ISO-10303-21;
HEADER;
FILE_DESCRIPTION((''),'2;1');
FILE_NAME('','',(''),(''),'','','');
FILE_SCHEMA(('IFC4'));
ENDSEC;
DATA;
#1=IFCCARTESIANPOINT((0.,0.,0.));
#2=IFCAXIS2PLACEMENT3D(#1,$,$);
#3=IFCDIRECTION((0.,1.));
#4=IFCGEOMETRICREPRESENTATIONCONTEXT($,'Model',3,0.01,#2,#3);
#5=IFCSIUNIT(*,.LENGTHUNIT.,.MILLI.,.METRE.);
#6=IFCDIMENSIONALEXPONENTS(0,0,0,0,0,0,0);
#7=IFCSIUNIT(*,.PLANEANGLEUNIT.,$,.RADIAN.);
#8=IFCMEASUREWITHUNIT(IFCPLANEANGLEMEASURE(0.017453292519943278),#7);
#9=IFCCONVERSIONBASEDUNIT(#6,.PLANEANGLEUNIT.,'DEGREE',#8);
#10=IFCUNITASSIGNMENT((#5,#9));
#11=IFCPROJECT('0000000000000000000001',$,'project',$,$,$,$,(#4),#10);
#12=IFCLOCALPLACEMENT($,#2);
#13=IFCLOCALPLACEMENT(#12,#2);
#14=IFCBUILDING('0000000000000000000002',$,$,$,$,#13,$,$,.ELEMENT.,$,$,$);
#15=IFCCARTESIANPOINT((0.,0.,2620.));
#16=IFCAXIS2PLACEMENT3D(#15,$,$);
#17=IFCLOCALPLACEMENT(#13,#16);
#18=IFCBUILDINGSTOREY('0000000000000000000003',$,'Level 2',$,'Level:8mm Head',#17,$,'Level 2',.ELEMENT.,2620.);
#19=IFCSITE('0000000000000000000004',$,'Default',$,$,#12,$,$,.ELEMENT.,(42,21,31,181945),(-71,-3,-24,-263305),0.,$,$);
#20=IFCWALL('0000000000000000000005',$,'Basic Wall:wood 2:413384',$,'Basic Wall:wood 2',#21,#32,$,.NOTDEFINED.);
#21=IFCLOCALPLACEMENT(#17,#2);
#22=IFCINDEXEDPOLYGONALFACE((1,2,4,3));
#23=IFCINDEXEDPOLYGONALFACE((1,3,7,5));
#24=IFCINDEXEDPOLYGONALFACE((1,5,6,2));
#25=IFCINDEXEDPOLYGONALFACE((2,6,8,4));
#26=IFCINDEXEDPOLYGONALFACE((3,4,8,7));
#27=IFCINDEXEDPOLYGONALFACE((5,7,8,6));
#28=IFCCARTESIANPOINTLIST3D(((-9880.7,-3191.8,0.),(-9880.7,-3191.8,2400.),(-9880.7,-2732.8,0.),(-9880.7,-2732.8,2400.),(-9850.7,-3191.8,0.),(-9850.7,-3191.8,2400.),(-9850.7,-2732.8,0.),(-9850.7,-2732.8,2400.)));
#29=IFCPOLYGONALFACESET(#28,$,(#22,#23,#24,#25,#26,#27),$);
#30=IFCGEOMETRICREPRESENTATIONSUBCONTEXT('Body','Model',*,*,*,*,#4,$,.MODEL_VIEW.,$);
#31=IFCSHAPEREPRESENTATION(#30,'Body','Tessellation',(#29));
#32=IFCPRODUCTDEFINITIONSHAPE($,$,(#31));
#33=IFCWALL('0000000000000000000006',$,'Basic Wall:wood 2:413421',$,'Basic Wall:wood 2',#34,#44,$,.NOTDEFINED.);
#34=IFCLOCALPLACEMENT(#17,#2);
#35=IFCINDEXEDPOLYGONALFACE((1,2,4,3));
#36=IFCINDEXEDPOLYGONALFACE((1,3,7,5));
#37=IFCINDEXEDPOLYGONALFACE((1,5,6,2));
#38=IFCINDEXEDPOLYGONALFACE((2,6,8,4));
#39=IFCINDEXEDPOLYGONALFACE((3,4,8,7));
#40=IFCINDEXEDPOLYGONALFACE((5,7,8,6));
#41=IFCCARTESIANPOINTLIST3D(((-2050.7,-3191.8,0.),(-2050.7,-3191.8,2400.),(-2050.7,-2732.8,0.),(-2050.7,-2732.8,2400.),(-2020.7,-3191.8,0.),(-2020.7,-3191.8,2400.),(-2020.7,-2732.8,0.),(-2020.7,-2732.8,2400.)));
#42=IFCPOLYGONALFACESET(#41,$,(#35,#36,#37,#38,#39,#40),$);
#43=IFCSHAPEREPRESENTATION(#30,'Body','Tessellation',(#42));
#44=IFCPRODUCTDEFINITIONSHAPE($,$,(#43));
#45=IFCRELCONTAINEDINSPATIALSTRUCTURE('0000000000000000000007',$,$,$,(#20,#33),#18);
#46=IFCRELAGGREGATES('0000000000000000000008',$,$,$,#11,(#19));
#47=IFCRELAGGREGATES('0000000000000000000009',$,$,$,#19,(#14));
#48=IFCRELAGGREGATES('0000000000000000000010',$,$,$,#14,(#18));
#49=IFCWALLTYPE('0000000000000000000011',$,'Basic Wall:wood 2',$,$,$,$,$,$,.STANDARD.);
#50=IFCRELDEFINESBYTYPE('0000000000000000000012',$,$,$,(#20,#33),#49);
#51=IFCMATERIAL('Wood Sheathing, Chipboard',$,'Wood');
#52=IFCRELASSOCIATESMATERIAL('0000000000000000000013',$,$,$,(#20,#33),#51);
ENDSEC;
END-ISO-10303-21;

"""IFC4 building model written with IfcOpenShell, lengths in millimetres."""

from ifc_helpers import new_model, entity, si_unit, converted_unit, direction, frame, origin, place, context, subcontext, project, spatial, indexed_curve, outline, extrude, material, type_object, element, save


model = new_model("IFC4")

# Units and contexts
model_context = context("Model", 3, precision=0.01, world=origin(), true_north=direction((0.0, 1.0)))
body_context = subcontext(model_context, "Body", "Model", "MODEL_VIEW")
ifc_project = project(units=[si_unit("LENGTHUNIT", "METRE", prefix="MILLI"), converted_unit("PLANEANGLEUNIT", "DEGREE", entity("IfcPlaneAngleMeasure", 0.017453292519943278), si_unit("PLANEANGLEUNIT", "RADIAN"), dimensions=[0, 0, 0, 0, 0, 0, 0])], contexts=[model_context])

# Site, building, storey
site_placement = place(None, origin())
site = spatial("IfcSite", under=ifc_project, at=site_placement, Name="Default", CompositionType="ELEMENT", RefLatitude=(42, 21, 31, 181945), RefLongitude=(-71, -3, -24, -263305), RefElevation=0.0)
building_placement = place(site_placement, origin())
building = spatial("IfcBuilding", under=site, at=building_placement, CompositionType="ELEMENT")
storey_placement = place(building_placement, frame((0.0, 0.0, 2620.0)))
storey = spatial("IfcBuildingStorey", under=building, at=storey_placement, Name="Level 2", ObjectType="Level:8mm Head", LongName="Level 2", CompositionType="ELEMENT", Elevation=2620.0)

# Shared definitions
ifc_material_1 = material(Name="Wood Sheathing, Chipboard", Category="Wood")

# Walls
wall_type_1 = type_object("IfcWallType", Name="Basic Wall:wood 2", PredefinedType="STANDARD")
wall_1_placement = place(storey_placement, frame((-9865.7, -3191.8, 0.0), z_axis=(0.0, 0.0, 1.0), x_axis=(0.0, 1.0, 0.0)))
element("IfcWall", 1, at=wall_1_placement, inside=storey, type_object=wall_type_1, material=ifc_material_1, Name="Basic Wall:wood 2:413384", ObjectType="Basic Wall:wood 2", PredefinedType="NOTDEFINED", context=body_context, shape_type="SweptSolid", body=[
    extrude(outline(indexed_curve([(459.0, 15.0), (0.0, 15.0), (0.0, -15.0), (459.0, -15.0), (459.0, 15.0)], self_intersect=False)), origin(), (0.0, 0.0, 1.0), 2400.0),
])
wall_2_placement = place(storey_placement, frame((-2035.7, -3191.8, 0.0), z_axis=(0.0, 0.0, 1.0), x_axis=(0.0, 1.0, 0.0)))
element("IfcWall", 2, at=wall_2_placement, inside=storey, type_object=wall_type_1, material=ifc_material_1, Name="Basic Wall:wood 2:413421", ObjectType="Basic Wall:wood 2", PredefinedType="NOTDEFINED", context=body_context, shape_type="SweptSolid", body=[
    extrude(outline(indexed_curve([(459.0, 15.0), (0.0, 15.0), (0.0, -15.0), (459.0, -15.0), (459.0, 15.0)], self_intersect=False)), origin(), (0.0, 0.0, 1.0), 2400.0),
])

save(model, "model.ifc")
